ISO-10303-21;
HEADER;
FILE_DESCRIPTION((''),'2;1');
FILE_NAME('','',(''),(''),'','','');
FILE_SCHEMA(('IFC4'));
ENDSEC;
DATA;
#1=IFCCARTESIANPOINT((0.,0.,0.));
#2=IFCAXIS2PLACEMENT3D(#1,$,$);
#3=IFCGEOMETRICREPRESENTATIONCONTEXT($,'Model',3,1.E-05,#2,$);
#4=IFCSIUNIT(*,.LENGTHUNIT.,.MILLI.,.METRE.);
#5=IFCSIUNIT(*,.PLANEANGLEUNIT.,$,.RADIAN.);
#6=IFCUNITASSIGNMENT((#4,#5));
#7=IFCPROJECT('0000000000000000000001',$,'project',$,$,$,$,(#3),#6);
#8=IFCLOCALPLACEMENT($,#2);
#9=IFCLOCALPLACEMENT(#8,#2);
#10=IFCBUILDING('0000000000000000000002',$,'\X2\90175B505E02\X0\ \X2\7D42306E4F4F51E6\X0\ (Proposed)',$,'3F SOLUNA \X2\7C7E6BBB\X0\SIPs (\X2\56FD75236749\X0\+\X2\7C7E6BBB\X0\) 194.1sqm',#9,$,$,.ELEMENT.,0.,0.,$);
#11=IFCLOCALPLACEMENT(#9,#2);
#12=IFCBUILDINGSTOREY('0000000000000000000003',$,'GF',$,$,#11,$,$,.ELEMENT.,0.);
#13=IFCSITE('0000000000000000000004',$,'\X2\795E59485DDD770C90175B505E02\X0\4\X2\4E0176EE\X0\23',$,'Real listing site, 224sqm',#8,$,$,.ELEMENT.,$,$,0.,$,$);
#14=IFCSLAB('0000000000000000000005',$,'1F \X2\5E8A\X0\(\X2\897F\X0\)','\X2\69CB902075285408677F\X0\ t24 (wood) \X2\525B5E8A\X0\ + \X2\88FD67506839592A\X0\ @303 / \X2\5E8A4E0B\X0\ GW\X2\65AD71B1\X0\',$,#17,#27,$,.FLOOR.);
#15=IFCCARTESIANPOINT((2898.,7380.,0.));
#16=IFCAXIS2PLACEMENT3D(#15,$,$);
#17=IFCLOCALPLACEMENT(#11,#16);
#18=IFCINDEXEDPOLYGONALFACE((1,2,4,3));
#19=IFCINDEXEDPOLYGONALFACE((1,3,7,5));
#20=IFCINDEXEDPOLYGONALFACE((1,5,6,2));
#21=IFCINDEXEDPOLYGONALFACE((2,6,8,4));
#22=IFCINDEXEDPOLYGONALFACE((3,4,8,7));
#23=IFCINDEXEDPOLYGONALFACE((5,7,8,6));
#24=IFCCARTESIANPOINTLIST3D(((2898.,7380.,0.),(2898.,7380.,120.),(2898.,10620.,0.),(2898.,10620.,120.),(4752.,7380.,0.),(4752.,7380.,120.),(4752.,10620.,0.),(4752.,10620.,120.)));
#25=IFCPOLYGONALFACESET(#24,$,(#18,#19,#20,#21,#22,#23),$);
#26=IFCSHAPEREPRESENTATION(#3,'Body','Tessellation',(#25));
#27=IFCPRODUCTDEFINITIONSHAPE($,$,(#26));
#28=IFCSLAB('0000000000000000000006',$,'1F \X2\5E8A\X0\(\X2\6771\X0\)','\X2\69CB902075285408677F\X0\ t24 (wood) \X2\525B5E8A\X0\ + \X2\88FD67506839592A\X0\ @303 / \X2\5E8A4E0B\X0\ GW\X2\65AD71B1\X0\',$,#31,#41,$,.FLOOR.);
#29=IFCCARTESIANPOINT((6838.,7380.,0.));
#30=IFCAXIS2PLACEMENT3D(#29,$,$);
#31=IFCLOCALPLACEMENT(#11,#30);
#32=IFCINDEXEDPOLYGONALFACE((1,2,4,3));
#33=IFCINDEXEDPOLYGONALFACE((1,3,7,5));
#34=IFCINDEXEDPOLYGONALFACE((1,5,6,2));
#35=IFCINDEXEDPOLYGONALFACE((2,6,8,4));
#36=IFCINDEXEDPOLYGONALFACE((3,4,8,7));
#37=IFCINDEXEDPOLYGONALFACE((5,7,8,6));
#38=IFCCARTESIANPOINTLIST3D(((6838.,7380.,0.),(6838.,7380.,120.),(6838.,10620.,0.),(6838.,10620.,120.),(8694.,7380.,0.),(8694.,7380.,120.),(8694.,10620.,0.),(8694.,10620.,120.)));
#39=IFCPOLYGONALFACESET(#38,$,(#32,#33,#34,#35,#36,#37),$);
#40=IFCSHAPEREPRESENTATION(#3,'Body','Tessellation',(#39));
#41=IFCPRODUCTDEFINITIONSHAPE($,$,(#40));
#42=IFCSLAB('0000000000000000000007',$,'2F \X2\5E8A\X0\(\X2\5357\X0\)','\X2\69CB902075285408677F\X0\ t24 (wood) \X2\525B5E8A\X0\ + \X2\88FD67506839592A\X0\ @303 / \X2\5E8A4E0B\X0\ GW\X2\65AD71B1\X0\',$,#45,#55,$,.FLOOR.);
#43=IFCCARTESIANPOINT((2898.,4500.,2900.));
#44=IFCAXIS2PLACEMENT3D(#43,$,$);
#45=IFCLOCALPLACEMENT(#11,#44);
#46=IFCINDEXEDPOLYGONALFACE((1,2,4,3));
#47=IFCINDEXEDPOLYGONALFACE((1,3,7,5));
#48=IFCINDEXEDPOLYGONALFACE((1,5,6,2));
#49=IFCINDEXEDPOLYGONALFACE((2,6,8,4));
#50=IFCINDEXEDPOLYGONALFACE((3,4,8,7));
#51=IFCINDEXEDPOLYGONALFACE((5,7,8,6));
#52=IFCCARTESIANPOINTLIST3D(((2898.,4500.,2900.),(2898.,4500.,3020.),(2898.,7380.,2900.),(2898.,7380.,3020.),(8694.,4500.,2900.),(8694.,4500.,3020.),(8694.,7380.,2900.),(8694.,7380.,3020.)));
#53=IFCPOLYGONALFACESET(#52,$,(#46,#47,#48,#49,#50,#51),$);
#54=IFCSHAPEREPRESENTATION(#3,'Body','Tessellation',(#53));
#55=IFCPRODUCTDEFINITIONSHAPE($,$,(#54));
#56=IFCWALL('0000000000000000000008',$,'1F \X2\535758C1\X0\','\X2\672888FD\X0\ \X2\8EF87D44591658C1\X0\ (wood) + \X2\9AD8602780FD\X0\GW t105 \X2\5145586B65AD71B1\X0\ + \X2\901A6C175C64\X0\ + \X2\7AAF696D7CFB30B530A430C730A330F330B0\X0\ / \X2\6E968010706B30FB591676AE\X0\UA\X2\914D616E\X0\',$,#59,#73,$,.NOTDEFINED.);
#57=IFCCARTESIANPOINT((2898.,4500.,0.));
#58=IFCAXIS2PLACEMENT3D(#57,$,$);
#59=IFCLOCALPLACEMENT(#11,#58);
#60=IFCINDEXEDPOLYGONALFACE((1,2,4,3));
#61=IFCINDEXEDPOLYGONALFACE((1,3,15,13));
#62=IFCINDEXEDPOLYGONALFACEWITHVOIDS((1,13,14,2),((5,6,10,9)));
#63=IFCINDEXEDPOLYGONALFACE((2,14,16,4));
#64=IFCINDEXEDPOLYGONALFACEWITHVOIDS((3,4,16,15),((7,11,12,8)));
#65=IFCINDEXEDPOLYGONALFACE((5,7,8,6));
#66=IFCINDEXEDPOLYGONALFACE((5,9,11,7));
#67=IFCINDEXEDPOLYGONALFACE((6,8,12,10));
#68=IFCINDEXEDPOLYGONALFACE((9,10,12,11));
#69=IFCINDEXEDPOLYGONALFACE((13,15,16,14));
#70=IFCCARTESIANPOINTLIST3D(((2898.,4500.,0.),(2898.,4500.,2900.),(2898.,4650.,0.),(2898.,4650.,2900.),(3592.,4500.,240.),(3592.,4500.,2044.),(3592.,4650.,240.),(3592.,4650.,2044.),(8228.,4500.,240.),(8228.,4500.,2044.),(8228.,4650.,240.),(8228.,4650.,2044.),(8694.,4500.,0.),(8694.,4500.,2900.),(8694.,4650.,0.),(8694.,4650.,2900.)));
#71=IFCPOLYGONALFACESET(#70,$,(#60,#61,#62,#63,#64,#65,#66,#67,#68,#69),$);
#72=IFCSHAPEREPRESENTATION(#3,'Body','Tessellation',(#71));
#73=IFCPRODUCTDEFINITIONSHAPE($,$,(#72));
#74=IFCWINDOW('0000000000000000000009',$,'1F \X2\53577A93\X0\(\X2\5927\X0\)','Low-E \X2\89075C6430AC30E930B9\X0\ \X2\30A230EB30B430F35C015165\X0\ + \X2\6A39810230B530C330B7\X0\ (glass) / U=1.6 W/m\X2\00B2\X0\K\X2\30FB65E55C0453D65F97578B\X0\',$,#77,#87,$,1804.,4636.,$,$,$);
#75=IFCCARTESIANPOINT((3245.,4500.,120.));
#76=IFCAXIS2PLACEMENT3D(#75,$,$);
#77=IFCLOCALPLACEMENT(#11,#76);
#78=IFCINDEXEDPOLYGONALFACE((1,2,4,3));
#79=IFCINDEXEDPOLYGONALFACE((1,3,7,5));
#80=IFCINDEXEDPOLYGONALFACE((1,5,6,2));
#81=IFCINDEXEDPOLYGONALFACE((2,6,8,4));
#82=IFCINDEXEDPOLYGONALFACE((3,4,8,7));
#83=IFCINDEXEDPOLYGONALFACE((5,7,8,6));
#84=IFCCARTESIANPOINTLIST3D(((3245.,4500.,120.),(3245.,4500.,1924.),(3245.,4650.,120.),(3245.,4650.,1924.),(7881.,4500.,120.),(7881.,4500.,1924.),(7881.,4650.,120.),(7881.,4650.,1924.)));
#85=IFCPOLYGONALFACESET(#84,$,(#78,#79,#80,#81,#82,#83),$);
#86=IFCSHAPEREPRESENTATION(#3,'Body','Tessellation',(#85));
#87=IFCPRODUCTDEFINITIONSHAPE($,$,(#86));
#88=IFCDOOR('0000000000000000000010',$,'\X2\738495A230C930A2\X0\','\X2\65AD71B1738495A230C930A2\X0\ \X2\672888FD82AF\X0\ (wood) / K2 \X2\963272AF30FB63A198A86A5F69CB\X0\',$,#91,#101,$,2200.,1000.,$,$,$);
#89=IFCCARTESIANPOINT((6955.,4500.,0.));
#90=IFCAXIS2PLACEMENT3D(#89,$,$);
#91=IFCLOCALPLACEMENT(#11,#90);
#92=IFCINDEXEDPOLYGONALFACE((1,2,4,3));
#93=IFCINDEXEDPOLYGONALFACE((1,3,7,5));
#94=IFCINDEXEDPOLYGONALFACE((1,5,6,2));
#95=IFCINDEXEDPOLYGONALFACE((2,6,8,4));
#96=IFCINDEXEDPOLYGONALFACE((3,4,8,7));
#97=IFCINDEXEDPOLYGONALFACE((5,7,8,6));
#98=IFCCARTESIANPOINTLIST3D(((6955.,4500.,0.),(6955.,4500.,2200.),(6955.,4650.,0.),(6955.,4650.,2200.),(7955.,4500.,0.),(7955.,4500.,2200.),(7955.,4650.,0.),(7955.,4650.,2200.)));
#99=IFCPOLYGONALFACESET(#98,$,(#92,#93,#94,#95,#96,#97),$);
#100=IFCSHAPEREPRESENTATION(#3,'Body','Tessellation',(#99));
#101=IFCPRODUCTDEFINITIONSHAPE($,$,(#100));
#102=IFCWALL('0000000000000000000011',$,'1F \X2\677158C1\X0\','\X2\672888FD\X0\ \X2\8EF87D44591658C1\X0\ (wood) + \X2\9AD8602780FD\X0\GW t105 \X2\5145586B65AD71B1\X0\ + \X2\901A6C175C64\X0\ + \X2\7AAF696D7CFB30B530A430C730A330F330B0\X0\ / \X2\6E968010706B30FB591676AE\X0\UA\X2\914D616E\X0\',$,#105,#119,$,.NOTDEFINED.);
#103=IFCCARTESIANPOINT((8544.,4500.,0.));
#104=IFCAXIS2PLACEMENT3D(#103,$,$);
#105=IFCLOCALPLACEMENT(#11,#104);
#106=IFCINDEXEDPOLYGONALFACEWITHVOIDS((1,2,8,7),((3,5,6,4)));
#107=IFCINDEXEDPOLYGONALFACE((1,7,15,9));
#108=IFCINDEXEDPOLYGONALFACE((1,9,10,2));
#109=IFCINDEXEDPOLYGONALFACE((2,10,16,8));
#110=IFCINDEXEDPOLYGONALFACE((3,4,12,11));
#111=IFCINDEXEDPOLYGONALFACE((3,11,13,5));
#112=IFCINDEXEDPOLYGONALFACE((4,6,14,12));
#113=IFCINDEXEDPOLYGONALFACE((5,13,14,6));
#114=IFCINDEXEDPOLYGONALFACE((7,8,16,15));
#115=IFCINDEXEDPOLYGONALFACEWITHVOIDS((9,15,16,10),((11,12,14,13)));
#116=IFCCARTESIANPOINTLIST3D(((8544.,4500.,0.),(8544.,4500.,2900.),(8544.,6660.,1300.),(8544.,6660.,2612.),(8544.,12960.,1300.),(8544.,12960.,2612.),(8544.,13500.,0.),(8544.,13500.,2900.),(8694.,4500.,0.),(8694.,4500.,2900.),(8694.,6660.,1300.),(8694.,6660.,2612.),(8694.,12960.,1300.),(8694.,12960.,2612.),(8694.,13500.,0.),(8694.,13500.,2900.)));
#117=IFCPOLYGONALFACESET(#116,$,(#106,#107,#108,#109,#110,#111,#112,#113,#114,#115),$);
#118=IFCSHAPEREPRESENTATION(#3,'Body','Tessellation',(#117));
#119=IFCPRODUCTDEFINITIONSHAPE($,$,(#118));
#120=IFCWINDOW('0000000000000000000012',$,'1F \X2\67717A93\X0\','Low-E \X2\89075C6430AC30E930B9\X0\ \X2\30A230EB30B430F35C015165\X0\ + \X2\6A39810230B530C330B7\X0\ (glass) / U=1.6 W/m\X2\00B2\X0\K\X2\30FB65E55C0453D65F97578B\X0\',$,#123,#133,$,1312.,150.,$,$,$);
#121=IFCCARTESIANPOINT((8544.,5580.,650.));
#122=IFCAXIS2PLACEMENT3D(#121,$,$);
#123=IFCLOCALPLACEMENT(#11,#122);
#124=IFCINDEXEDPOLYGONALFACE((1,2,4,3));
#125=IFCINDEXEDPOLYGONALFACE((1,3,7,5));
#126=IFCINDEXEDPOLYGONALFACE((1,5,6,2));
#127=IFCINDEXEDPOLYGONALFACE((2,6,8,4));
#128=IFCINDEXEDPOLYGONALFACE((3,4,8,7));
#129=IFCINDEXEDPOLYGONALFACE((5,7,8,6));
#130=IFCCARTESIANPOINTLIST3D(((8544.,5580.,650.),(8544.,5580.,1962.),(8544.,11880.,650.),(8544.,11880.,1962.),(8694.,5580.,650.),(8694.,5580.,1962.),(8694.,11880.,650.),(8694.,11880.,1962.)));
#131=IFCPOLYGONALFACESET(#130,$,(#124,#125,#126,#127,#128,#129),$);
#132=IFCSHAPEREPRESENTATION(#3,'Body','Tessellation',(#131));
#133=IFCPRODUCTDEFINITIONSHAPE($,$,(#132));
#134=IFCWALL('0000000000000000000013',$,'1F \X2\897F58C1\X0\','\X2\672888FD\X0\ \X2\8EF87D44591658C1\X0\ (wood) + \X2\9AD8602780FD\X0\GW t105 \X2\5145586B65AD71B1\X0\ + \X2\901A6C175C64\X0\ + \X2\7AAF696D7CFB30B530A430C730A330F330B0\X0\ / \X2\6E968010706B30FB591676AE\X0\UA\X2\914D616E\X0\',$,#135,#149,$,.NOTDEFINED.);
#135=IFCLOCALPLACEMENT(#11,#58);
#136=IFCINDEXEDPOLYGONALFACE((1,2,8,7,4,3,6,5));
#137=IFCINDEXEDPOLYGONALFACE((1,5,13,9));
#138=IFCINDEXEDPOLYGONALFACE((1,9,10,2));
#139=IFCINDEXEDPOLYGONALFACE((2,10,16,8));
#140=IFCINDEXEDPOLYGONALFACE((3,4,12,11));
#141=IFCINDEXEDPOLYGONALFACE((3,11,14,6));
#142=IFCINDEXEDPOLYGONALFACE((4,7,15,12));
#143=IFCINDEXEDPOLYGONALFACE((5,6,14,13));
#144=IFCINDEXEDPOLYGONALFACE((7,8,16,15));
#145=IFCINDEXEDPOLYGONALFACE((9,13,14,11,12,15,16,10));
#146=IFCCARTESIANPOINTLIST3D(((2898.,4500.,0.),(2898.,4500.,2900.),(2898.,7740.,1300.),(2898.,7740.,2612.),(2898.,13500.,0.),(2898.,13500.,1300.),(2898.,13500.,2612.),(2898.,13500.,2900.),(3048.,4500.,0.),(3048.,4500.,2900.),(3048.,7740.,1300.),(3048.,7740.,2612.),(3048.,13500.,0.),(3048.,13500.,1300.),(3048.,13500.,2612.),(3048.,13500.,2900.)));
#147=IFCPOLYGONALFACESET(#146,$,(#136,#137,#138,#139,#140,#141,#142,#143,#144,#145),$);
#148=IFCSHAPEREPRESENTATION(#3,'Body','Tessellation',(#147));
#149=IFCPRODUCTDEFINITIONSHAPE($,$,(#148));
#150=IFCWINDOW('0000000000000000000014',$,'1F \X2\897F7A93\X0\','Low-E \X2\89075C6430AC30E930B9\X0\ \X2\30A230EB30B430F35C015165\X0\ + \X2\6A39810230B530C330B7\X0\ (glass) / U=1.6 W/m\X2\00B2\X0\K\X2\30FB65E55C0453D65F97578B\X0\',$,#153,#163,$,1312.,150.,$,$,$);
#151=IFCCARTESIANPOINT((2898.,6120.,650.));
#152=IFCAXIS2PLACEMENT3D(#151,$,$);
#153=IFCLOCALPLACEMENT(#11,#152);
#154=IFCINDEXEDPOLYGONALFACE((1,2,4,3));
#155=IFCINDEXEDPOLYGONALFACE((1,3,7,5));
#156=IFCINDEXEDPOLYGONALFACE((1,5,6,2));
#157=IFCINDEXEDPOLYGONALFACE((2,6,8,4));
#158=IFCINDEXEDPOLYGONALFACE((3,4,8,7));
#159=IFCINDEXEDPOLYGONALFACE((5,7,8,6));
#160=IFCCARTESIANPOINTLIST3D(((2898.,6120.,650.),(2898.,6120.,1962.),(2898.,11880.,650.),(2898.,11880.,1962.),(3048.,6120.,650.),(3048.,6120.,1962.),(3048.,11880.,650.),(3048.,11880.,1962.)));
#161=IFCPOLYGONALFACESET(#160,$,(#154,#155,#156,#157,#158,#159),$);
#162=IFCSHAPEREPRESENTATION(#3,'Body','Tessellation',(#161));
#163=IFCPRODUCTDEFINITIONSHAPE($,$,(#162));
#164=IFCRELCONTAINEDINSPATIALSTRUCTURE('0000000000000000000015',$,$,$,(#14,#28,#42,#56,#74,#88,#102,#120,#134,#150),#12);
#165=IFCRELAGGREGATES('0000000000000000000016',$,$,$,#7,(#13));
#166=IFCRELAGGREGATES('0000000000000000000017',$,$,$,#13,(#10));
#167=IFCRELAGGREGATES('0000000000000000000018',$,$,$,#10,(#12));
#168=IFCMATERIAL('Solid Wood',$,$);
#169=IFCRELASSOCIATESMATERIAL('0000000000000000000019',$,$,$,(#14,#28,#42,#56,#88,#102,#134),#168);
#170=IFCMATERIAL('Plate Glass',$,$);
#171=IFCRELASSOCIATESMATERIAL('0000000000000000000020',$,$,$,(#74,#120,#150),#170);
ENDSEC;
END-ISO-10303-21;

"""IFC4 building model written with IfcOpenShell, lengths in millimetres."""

from ifc_helpers import new_model, si_unit, frame, frame_2d, origin, place, context, project, spatial, rectangle, extrude, material, element, fill, save


model = new_model("IFC4")

# Units and contexts
model_context = context("Model", 3, precision=1e-05, world=origin())
ifc_project = project(units=[si_unit("LENGTHUNIT", "METRE", prefix="MILLI"), si_unit("PLANEANGLEUNIT", "RADIAN")], contexts=[model_context])

# Site, building, storey
site_placement = place(None, origin())
site = spatial("IfcSite", under=ifc_project, at=site_placement, Name="神奈川県逗子市4丁目23", ObjectType="Real listing site, 224sqm", CompositionType="ELEMENT", RefElevation=0.0)
building_placement = place(site_placement, origin())
building = spatial("IfcBuilding", under=site, at=building_placement, Name="逗子市 終の住処 (Proposed)", ObjectType="3F SOLUNA 籾殻SIPs (国産杉+籾殻) 194.1sqm", CompositionType="ELEMENT", ElevationOfRefHeight=0.0, ElevationOfTerrain=0.0)
storey_placement = place(building_placement, origin())
storey = spatial("IfcBuildingStorey", under=building, at=storey_placement, Name="GF", CompositionType="ELEMENT", Elevation=0.0)

# Slabs
ifc_material_1 = material(Name="Solid Wood")
slab_1_placement = place(storey_placement, frame((2898.0, 7380.0, 0.0)))
element("IfcSlab", 1, at=slab_1_placement, inside=storey, material=ifc_material_1, Name="1F 床(西)", Description="構造用合板 t24 (wood) 剛床 + 製材根太 @303 / 床下 GW断熱", PredefinedType="FLOOR", context=model_context, shape_type="SweptSolid", body=[
    extrude(rectangle(XDim=1854.0, YDim=3240.0, at=frame_2d((927.0, 1620.0))), frame((2898.0, 7380.0, 0.0)), (0.0, 0.0, 1.0), 120.0),
])
slab_2_placement = place(storey_placement, frame((6838.0, 7380.0, 0.0)))
element("IfcSlab", 2, at=slab_2_placement, inside=storey, material=ifc_material_1, Name="1F 床(東)", Description="構造用合板 t24 (wood) 剛床 + 製材根太 @303 / 床下 GW断熱", PredefinedType="FLOOR", context=model_context, shape_type="SweptSolid", body=[
    extrude(rectangle(XDim=1856.0, YDim=3240.0, at=frame_2d((928.0, 1620.0))), frame((6838.0, 7380.0, 0.0)), (0.0, 0.0, 1.0), 120.0),
])
slab_3_placement = place(storey_placement, frame((2898.0, 4500.0, 2900.0)))
element("IfcSlab", 3, at=slab_3_placement, inside=storey, material=ifc_material_1, Name="2F 床(南)", Description="構造用合板 t24 (wood) 剛床 + 製材根太 @303 / 床下 GW断熱", PredefinedType="FLOOR", context=model_context, shape_type="SweptSolid", body=[
    extrude(rectangle(XDim=5796.0, YDim=2880.0, at=frame_2d((2898.0, 1440.0))), frame((2898.0, 4500.0, 2900.0)), (0.0, 0.0, 1.0), 120.0),
])

# Wall, openings, window, door
wall_1_placement = place(storey_placement, frame((2898.0, 4500.0, 0.0)))
wall_1 = element("IfcWall", 4, at=wall_1_placement, inside=storey, material=ifc_material_1, Name="1F 南壁", Description="木製 軸組外壁 (wood) + 高性能GW t105 充填断熱 + 通気層 + 窯業系サイディング / 準耐火・外皮UA配慮", PredefinedType="NOTDEFINED", context=model_context, shape_type="SweptSolid", body=[
    extrude(rectangle(XDim=5796.0, YDim=150.0, at=frame_2d((2898.0, 75.0))), frame((2898.0, 4500.0, 0.0)), (0.0, 0.0, 1.0), 2900.0),
])
opening_1_placement = place(storey_placement, frame((3245.0, 4500.0, 120.0)))
opening_1 = element("IfcOpeningElement", 5, at=opening_1_placement, cuts=wall_1, PredefinedType="NOTDEFINED", context=model_context, shape_type="SweptSolid", body=[
    extrude(rectangle(XDim=4636.0, YDim=150.0, at=frame_2d((2318.0, 75.0))), frame((3245.0, 4500.0, 120.0)), (0.0, 0.0, 1.0), 1804.0),
])
opening_2_placement = place(storey_placement, frame((6955.0, 4500.0, 0.0)))
opening_2 = element("IfcOpeningElement", 6, at=opening_2_placement, cuts=wall_1, PredefinedType="NOTDEFINED", context=model_context, shape_type="SweptSolid", body=[
    extrude(rectangle(XDim=1000.0, YDim=150.0, at=frame_2d((500.0, 75.0))), frame((6955.0, 4500.0, 0.0)), (0.0, 0.0, 1.0), 2200.0),
])
ifc_material_2 = material(Name="Plate Glass")
window_1_placement = place(storey_placement, frame((3245.0, 4500.0, 120.0)))
window_1 = element("IfcWindow", 7, at=window_1_placement, inside=storey, material=ifc_material_2, Name="1F 南窓(大)", Description="Low-E 複層ガラス アルゴン封入 + 樹脂サッシ (glass) / U=1.6 W/m²K・日射取得型", OverallHeight=1804.0, OverallWidth=4636.0, context=model_context, shape_type="SweptSolid", body=[
    extrude(rectangle(XDim=4636.0, YDim=150.0, at=frame_2d((2318.0, 75.0))), frame((3245.0, 4500.0, 120.0)), (0.0, 0.0, 1.0), 1804.0),
])
fill(opening_1, window_1)
door_placement = place(storey_placement, frame((6955.0, 4500.0, 0.0)))
door = element("IfcDoor", 8, at=door_placement, inside=storey, material=ifc_material_1, Name="玄関ドア", Description="断熱玄関ドア 木製芯 (wood) / K2 防犯・採風機構", OverallHeight=2200.0, OverallWidth=1000.0, context=model_context, shape_type="SweptSolid", body=[
    extrude(rectangle(XDim=1000.0, YDim=150.0, at=frame_2d((500.0, 75.0))), frame((6955.0, 4500.0, 0.0)), (0.0, 0.0, 1.0), 2200.0),
])
fill(opening_2, door)

# Walls, openings, windows
wall_2_placement = place(storey_placement, frame((8544.0, 4500.0, 0.0)))
wall_2 = element("IfcWall", 9, at=wall_2_placement, inside=storey, material=ifc_material_1, Name="1F 東壁", Description="木製 軸組外壁 (wood) + 高性能GW t105 充填断熱 + 通気層 + 窯業系サイディング / 準耐火・外皮UA配慮", PredefinedType="NOTDEFINED", context=model_context, shape_type="SweptSolid", body=[
    extrude(rectangle(XDim=150.0, YDim=9000.0, at=frame_2d((75.0, 4500.0))), frame((8544.0, 4500.0, 0.0)), (0.0, 0.0, 1.0), 2900.0),
])
opening_3_placement = place(storey_placement, frame((8544.0, 5580.0, 650.0)))
opening_3 = element("IfcOpeningElement", 10, at=opening_3_placement, cuts=wall_2, PredefinedType="NOTDEFINED", context=model_context, shape_type="SweptSolid", body=[
    extrude(rectangle(XDim=150.0, YDim=6300.0, at=frame_2d((75.0, 3150.0))), frame((8544.0, 5580.0, 650.0)), (0.0, 0.0, 1.0), 1312.0),
])
window_2_placement = place(storey_placement, frame((8544.0, 5580.0, 650.0)))
window_2 = element("IfcWindow", 11, at=window_2_placement, inside=storey, material=ifc_material_2, Name="1F 東窓", Description="Low-E 複層ガラス アルゴン封入 + 樹脂サッシ (glass) / U=1.6 W/m²K・日射取得型", OverallHeight=1312.0, OverallWidth=150.0, context=model_context, shape_type="SweptSolid", body=[
    extrude(rectangle(XDim=150.0, YDim=6300.0, at=frame_2d((75.0, 3150.0))), frame((8544.0, 5580.0, 650.0)), (0.0, 0.0, 1.0), 1312.0),
])
fill(opening_3, window_2)
wall_3_placement = place(storey_placement, frame((2898.0, 4500.0, 0.0)))
wall_3 = element("IfcWall", 12, at=wall_3_placement, inside=storey, material=ifc_material_1, Name="1F 西壁", Description="木製 軸組外壁 (wood) + 高性能GW t105 充填断熱 + 通気層 + 窯業系サイディング / 準耐火・外皮UA配慮", PredefinedType="NOTDEFINED", context=model_context, shape_type="SweptSolid", body=[
    extrude(rectangle(XDim=150.0, YDim=9000.0, at=frame_2d((75.0, 4500.0))), frame((2898.0, 4500.0, 0.0)), (0.0, 0.0, 1.0), 2900.0),
])
opening_4_placement = place(storey_placement, frame((2898.0, 6120.0, 650.0)))
opening_4 = element("IfcOpeningElement", 13, at=opening_4_placement, cuts=wall_3, PredefinedType="NOTDEFINED", context=model_context, shape_type="SweptSolid", body=[
    extrude(rectangle(XDim=150.0, YDim=5760.0, at=frame_2d((75.0, 2880.0))), frame((2898.0, 6120.0, 650.0)), (0.0, 0.0, 1.0), 1312.0),
])
window_3_placement = place(storey_placement, frame((2898.0, 6120.0, 650.0)))
window_3 = element("IfcWindow", 14, at=window_3_placement, inside=storey, material=ifc_material_2, Name="1F 西窓", Description="Low-E 複層ガラス アルゴン封入 + 樹脂サッシ (glass) / U=1.6 W/m²K・日射取得型", OverallHeight=1312.0, OverallWidth=150.0, context=model_context, shape_type="SweptSolid", body=[
    extrude(rectangle(XDim=150.0, YDim=5760.0, at=frame_2d((75.0, 2880.0))), frame((2898.0, 6120.0, 650.0)), (0.0, 0.0, 1.0), 1312.0),
])
fill(opening_4, window_3)

save(model, "model.ifc")
